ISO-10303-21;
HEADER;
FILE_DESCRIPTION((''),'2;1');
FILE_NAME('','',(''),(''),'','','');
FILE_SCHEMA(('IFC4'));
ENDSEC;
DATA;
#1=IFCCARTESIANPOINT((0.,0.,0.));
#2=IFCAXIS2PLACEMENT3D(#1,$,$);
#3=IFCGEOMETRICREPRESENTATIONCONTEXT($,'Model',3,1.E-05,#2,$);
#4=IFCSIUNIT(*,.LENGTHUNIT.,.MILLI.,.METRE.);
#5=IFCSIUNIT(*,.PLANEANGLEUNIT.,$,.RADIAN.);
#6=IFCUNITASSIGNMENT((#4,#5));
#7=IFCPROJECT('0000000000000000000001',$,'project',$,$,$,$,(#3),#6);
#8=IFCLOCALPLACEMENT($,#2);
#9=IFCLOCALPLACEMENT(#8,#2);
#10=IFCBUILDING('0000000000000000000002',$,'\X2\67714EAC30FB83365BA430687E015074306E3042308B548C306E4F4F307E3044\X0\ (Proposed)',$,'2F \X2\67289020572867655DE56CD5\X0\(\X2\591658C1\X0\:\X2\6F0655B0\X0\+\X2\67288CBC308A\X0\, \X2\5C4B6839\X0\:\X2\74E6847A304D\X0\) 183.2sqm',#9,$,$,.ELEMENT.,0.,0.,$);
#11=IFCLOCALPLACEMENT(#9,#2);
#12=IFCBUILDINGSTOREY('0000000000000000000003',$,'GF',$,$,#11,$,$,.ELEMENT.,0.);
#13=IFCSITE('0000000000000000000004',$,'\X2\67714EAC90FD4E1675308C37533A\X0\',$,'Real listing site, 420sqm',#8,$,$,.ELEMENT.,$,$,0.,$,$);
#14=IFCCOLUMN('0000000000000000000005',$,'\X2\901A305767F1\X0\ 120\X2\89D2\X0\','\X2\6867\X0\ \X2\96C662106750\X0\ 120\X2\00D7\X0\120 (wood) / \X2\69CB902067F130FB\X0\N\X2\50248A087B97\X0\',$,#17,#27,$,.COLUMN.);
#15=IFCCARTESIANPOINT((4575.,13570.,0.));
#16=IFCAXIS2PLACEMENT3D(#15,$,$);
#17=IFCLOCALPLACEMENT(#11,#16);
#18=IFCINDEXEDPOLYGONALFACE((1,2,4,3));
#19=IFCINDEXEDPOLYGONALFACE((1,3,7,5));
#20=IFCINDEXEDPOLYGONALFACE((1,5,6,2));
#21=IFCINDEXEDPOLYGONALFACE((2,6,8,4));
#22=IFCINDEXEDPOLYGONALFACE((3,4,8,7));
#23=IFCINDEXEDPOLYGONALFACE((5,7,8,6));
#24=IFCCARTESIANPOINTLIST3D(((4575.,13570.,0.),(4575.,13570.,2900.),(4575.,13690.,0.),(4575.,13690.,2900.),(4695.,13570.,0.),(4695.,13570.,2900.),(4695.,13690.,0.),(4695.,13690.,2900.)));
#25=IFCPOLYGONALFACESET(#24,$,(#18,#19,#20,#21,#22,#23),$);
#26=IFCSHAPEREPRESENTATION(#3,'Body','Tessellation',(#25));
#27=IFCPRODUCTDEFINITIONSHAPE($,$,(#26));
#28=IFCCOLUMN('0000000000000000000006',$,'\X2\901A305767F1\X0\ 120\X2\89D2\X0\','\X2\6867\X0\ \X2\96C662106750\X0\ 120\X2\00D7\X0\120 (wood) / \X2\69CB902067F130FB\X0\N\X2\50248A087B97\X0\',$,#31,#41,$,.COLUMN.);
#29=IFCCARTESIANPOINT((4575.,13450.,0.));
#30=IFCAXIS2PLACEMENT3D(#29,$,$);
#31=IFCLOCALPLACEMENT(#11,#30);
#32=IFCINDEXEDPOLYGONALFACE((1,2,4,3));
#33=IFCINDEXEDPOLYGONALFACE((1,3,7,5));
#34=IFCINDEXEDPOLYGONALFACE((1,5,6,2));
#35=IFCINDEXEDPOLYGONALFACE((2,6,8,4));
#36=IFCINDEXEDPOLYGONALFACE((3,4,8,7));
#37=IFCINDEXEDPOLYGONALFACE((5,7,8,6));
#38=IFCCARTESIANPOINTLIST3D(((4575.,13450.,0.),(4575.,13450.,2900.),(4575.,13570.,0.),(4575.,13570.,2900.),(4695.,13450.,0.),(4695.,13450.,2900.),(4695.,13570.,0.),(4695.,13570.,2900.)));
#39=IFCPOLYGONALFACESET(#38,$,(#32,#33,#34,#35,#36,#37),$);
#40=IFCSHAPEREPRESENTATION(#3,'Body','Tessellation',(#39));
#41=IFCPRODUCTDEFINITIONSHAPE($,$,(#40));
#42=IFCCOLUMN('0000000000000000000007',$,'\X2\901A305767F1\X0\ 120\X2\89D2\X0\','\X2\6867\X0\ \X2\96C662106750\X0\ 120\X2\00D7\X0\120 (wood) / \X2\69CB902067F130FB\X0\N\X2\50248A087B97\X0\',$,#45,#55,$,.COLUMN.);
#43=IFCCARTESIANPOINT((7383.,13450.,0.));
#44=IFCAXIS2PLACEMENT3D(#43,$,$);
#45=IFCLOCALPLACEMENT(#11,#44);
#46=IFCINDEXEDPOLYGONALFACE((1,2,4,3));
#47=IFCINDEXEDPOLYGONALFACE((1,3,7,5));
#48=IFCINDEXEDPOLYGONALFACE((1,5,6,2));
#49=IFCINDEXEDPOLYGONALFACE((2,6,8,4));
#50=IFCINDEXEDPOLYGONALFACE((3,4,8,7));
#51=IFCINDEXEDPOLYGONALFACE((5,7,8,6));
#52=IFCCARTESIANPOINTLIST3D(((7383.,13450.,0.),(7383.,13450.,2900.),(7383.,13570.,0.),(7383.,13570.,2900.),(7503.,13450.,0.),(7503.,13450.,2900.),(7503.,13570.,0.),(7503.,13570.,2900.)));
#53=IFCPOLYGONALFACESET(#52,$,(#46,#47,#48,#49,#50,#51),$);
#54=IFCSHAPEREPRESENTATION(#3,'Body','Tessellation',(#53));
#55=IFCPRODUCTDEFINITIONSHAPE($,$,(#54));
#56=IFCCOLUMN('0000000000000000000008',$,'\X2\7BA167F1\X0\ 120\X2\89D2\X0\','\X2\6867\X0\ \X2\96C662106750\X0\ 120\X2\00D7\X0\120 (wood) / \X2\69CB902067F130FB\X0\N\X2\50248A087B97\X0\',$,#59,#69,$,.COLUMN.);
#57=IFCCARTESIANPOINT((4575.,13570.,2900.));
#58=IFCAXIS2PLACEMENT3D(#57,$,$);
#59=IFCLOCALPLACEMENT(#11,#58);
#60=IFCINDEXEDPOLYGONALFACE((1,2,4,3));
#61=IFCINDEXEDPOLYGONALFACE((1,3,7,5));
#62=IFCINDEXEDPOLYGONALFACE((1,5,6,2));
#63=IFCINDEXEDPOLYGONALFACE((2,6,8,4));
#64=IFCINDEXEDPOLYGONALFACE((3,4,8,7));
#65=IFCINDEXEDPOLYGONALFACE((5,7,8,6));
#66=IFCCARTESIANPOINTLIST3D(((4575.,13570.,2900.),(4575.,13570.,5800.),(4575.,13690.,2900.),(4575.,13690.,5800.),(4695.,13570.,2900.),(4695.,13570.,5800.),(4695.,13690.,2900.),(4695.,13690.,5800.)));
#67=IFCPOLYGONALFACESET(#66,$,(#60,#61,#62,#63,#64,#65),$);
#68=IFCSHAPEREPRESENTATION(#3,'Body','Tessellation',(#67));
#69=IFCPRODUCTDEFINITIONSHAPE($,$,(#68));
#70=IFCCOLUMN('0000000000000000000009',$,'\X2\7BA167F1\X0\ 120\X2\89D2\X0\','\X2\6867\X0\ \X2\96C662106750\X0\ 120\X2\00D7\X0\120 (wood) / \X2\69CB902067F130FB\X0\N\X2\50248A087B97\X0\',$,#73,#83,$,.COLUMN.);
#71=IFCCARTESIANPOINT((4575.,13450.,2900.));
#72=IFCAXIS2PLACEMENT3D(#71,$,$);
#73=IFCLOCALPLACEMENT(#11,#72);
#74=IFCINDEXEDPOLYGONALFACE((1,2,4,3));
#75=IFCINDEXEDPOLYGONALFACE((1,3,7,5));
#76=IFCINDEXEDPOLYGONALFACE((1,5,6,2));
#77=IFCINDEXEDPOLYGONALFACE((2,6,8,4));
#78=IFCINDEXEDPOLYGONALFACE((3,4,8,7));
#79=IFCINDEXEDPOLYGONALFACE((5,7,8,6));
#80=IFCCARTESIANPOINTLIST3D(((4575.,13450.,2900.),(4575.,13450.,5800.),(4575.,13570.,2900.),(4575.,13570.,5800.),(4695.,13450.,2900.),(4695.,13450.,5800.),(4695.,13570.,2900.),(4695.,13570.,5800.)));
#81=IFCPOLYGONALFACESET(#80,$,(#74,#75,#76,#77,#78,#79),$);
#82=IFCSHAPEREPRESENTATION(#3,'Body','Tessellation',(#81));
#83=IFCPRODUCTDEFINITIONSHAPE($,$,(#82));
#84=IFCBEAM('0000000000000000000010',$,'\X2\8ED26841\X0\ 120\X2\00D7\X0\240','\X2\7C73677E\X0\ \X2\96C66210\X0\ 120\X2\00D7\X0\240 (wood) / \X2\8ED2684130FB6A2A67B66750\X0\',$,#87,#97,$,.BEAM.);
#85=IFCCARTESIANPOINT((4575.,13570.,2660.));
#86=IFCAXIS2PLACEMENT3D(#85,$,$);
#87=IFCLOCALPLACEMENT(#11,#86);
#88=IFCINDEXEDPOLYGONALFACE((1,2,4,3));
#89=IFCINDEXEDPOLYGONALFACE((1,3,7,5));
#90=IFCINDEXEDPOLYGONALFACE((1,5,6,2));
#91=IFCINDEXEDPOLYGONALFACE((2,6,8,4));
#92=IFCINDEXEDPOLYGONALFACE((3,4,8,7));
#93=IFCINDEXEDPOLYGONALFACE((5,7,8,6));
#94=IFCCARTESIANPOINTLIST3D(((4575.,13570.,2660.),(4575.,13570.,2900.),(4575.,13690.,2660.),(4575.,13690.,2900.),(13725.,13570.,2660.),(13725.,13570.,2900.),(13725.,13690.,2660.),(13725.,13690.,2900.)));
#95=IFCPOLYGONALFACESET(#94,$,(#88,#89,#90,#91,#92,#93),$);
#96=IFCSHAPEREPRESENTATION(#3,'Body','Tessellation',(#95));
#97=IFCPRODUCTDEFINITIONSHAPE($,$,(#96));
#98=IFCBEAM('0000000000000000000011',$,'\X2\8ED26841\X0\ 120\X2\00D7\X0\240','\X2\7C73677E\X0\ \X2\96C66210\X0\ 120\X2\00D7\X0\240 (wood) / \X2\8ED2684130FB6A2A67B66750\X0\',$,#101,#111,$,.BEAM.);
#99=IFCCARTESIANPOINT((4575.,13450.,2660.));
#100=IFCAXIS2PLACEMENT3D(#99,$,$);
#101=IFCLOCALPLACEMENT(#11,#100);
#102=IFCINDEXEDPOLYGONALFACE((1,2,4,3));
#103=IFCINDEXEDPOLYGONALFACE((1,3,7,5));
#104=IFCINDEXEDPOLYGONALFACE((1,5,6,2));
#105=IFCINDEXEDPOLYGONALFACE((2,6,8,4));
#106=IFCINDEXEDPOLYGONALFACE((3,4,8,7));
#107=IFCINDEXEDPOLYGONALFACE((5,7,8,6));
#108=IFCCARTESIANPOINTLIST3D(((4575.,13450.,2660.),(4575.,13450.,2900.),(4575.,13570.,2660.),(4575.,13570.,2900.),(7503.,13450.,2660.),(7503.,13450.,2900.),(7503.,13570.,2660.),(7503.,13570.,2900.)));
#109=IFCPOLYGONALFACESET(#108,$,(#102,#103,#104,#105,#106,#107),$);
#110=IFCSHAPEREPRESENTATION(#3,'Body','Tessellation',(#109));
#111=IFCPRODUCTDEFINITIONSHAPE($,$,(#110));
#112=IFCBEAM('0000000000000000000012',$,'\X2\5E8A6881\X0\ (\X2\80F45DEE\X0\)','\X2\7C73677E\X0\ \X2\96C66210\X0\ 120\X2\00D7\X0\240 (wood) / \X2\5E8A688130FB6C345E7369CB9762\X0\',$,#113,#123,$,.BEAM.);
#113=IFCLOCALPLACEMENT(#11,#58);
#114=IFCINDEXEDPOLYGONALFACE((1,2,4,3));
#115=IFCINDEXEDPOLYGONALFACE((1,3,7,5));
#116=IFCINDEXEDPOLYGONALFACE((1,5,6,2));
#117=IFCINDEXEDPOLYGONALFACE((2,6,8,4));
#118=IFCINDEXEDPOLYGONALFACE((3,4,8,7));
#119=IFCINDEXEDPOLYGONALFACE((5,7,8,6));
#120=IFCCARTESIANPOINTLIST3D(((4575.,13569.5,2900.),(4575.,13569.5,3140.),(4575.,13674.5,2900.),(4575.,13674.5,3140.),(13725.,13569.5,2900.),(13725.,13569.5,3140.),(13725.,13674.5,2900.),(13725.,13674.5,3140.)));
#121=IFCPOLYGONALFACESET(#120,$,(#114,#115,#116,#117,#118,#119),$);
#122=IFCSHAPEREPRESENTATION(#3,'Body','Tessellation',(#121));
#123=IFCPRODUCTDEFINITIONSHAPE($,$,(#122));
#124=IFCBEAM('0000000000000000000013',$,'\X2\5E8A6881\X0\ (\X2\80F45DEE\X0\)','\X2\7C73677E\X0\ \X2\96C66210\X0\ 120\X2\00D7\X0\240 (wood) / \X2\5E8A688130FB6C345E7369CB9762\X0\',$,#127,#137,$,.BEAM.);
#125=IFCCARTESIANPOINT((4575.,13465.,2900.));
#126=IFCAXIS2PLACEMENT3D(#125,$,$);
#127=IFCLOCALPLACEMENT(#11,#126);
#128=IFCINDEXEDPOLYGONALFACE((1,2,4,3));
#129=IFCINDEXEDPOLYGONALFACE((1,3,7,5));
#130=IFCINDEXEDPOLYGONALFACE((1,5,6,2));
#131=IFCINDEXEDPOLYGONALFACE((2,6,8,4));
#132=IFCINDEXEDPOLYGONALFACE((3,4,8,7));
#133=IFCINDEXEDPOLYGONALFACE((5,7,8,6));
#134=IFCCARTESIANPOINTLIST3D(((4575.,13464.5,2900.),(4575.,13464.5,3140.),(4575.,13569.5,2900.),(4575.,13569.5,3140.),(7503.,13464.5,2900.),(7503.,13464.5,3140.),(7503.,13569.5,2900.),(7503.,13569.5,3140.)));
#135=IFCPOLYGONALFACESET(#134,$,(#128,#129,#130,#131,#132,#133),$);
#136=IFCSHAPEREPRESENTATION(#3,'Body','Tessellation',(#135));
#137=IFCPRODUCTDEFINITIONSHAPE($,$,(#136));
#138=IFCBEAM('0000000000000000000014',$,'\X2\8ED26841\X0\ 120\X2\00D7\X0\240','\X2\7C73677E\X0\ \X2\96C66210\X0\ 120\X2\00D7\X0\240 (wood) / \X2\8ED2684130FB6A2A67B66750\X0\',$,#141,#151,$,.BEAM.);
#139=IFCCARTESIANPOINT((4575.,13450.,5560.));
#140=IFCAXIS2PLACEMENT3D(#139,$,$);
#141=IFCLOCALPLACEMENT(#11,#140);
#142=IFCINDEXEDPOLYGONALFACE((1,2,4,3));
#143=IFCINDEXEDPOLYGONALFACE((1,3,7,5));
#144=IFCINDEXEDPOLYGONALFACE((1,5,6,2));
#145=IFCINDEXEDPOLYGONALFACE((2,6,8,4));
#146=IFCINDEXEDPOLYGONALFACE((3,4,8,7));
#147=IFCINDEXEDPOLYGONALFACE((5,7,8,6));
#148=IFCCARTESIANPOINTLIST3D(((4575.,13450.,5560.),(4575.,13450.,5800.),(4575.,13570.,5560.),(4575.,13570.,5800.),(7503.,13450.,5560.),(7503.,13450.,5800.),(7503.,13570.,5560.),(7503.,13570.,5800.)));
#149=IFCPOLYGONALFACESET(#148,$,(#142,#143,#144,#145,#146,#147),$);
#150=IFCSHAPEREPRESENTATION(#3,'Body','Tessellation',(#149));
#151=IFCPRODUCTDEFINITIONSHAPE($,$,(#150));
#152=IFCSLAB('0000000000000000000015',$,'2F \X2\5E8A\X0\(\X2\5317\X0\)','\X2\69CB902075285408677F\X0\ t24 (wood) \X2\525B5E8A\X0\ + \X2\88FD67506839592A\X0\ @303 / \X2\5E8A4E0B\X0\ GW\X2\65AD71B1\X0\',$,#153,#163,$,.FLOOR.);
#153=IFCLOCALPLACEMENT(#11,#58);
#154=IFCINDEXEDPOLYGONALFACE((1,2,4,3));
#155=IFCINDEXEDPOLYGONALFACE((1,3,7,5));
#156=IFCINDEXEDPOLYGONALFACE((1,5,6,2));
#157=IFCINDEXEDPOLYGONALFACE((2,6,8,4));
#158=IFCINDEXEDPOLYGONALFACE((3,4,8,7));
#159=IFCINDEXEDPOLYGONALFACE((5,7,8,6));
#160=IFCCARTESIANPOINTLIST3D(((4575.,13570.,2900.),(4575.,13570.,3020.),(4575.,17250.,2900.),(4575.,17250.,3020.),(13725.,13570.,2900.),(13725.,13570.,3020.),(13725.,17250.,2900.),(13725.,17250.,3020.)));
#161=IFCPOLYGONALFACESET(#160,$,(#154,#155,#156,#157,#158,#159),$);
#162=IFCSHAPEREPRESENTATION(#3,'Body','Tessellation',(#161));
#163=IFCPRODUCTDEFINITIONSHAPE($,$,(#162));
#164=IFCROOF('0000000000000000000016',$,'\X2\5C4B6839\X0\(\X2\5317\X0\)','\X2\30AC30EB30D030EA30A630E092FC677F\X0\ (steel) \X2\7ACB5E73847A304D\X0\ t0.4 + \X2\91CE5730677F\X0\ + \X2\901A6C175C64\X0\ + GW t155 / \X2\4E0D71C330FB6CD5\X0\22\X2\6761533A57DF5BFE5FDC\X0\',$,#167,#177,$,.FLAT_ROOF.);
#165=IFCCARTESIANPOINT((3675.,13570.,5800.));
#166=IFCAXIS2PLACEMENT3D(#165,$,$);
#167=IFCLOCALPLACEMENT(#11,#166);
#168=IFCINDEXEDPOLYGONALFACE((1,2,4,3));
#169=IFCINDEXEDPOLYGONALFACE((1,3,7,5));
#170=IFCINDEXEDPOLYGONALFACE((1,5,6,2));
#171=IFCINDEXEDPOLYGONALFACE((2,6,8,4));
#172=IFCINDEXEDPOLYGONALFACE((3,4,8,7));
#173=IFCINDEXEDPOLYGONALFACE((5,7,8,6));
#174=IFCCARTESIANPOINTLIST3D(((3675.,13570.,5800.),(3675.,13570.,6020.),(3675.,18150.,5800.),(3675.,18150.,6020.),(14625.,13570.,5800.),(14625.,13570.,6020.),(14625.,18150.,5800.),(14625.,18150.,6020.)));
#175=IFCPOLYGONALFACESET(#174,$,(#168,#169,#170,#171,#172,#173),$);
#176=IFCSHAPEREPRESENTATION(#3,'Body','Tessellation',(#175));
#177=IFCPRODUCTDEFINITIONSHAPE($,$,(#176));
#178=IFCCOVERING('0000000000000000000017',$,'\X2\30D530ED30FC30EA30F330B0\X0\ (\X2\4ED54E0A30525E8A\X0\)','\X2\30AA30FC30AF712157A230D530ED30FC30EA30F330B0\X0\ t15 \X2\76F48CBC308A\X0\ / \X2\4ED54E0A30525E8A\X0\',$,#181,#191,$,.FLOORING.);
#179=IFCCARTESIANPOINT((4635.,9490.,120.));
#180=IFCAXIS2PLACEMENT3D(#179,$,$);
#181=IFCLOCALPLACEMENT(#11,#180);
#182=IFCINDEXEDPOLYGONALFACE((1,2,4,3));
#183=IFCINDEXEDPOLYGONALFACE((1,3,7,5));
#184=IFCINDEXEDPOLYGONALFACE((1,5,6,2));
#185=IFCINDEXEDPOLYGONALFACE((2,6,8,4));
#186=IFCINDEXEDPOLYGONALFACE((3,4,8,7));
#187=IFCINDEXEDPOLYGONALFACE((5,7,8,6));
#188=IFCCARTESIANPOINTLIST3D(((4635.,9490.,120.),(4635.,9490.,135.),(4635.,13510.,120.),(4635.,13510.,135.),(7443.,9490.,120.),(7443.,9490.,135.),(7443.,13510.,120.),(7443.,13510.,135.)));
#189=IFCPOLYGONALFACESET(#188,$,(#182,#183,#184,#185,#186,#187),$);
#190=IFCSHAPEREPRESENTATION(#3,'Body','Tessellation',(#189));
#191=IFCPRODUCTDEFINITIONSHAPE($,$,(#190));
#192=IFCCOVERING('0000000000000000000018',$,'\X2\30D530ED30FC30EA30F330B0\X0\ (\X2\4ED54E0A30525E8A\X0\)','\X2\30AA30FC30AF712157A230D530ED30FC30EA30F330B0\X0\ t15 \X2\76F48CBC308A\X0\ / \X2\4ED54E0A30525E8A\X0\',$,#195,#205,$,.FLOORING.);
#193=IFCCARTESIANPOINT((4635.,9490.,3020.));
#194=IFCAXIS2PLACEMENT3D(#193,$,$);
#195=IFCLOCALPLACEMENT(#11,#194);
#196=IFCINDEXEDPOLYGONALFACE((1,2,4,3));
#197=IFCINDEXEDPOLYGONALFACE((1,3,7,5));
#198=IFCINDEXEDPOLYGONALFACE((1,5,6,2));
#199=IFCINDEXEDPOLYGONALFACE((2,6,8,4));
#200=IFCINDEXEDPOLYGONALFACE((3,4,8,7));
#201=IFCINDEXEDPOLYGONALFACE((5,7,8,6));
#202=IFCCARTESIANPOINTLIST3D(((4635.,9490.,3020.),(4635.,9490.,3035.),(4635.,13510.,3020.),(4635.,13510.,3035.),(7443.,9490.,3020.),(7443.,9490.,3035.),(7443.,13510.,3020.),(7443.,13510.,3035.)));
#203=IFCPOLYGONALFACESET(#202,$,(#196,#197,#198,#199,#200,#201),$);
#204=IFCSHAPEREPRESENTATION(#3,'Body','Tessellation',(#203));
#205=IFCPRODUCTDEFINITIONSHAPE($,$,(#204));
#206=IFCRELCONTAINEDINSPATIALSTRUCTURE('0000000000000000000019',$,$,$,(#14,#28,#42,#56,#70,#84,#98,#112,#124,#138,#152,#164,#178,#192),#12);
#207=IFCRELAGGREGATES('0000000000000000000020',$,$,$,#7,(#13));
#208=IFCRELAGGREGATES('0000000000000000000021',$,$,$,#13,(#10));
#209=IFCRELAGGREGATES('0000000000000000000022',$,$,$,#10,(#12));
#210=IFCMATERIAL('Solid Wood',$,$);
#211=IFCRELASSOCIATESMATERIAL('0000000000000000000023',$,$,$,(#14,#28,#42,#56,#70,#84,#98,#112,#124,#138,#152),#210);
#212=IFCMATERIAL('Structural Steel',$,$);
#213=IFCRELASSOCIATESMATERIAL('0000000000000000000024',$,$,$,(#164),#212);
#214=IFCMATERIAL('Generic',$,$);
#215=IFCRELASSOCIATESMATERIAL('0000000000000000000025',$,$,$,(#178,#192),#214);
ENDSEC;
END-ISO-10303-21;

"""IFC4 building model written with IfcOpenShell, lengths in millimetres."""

from ifc_helpers import new_model, si_unit, frame, frame_2d, origin, place, context, project, spatial, rectangle, extrude, material, element, save


model = new_model("IFC4")

# Units and contexts
model_context = context("Model", 3, precision=1e-05, world=origin())
ifc_project = project(units=[si_unit("LENGTHUNIT", "METRE", prefix="MILLI"), si_unit("PLANEANGLEUNIT", "RADIAN")], contexts=[model_context])

# Site, building, storey
site_placement = place(None, origin())
site = spatial("IfcSite", under=ifc_project, at=site_placement, Name="東京都世田谷区", ObjectType="Real listing site, 420sqm", CompositionType="ELEMENT", RefElevation=0.0)
building_placement = place(site_placement, origin())
building = spatial("IfcBuilding", under=site, at=building_placement, Name="東京・茶室と縁側のある和の住まい (Proposed)", ObjectType="2F 木造在来工法(外壁:漆喰+木貼り, 屋根:瓦葺き) 183.2sqm", CompositionType="ELEMENT", ElevationOfRefHeight=0.0, ElevationOfTerrain=0.0)
storey_placement = place(building_placement, origin())
storey = spatial("IfcBuildingStorey", under=building, at=storey_placement, Name="GF", CompositionType="ELEMENT", Elevation=0.0)

# Columns
ifc_material_1 = material(Name="Solid Wood")
column_1_placement = place(storey_placement, frame((4575.0, 13570.0, 0.0)))
element("IfcColumn", 1, at=column_1_placement, inside=storey, material=ifc_material_1, Name="通し柱 120角", Description="桧 集成材 120×120 (wood) / 構造柱・N値計算", PredefinedType="COLUMN", context=model_context, shape_type="SweptSolid", body=[
    extrude(rectangle(XDim=120.0, YDim=120.0, at=frame_2d((60.0, 60.0))), frame((4575.0, 13570.0, 0.0)), (0.0, 0.0, 1.0), 2900.0),
])
column_2_placement = place(storey_placement, frame((4575.0, 13450.0, 0.0)))
element("IfcColumn", 2, at=column_2_placement, inside=storey, material=ifc_material_1, Name="通し柱 120角", Description="桧 集成材 120×120 (wood) / 構造柱・N値計算", PredefinedType="COLUMN", context=model_context, shape_type="SweptSolid", body=[
    extrude(rectangle(XDim=120.0, YDim=120.0, at=frame_2d((60.0, 60.0))), frame((4575.0, 13450.0, 0.0)), (0.0, 0.0, 1.0), 2900.0),
])
column_3_placement = place(storey_placement, frame((7383.0, 13450.0, 0.0)))
element("IfcColumn", 3, at=column_3_placement, inside=storey, material=ifc_material_1, Name="通し柱 120角", Description="桧 集成材 120×120 (wood) / 構造柱・N値計算", PredefinedType="COLUMN", context=model_context, shape_type="SweptSolid", body=[
    extrude(rectangle(XDim=120.0, YDim=120.0, at=frame_2d((60.0, 60.0))), frame((7383.0, 13450.0, 0.0)), (0.0, 0.0, 1.0), 2900.0),
])
column_4_placement = place(storey_placement, frame((4575.0, 13570.0, 2900.0)))
element("IfcColumn", 4, at=column_4_placement, inside=storey, material=ifc_material_1, Name="管柱 120角", Description="桧 集成材 120×120 (wood) / 構造柱・N値計算", PredefinedType="COLUMN", context=model_context, shape_type="SweptSolid", body=[
    extrude(rectangle(XDim=120.0, YDim=120.0, at=frame_2d((60.0, 60.0))), frame((4575.0, 13570.0, 2900.0)), (0.0, 0.0, 1.0), 2900.0),
])
column_5_placement = place(storey_placement, frame((4575.0, 13450.0, 2900.0)))
element("IfcColumn", 5, at=column_5_placement, inside=storey, material=ifc_material_1, Name="管柱 120角", Description="桧 集成材 120×120 (wood) / 構造柱・N値計算", PredefinedType="COLUMN", context=model_context, shape_type="SweptSolid", body=[
    extrude(rectangle(XDim=120.0, YDim=120.0, at=frame_2d((60.0, 60.0))), frame((4575.0, 13450.0, 2900.0)), (0.0, 0.0, 1.0), 2900.0),
])

# Beams
beam_1_placement = place(storey_placement, frame((4575.0, 13570.0, 2660.0)))
element("IfcBeam", 6, at=beam_1_placement, inside=storey, material=ifc_material_1, Name="軒桁 120×240", Description="米松 集成 120×240 (wood) / 軒桁・横架材", PredefinedType="BEAM", context=model_context, shape_type="SweptSolid", body=[
    extrude(rectangle(XDim=9150.0, YDim=120.0, at=frame_2d((4575.0, 60.0))), frame((4575.0, 13570.0, 2660.0)), (0.0, 0.0, 1.0), 240.0),
])
beam_2_placement = place(storey_placement, frame((4575.0, 13450.0, 2660.0)))
element("IfcBeam", 7, at=beam_2_placement, inside=storey, material=ifc_material_1, Name="軒桁 120×240", Description="米松 集成 120×240 (wood) / 軒桁・横架材", PredefinedType="BEAM", context=model_context, shape_type="SweptSolid", body=[
    extrude(rectangle(XDim=2928.0, YDim=120.0, at=frame_2d((1464.0, 60.0))), frame((4575.0, 13450.0, 2660.0)), (0.0, 0.0, 1.0), 240.0),
])
beam_3_placement = place(storey_placement, frame((4575.0, 13570.0, 2900.0)))
element("IfcBeam", 8, at=beam_3_placement, inside=storey, material=ifc_material_1, Name="床梁 (胴差)", Description="米松 集成 120×240 (wood) / 床梁・水平構面", PredefinedType="BEAM", context=model_context, shape_type="SweptSolid", body=[
    extrude(rectangle(XDim=9150.0, YDim=105.0, at=frame_2d((4575.0, 52.0))), frame((4575.0, 13570.0, 2900.0)), (0.0, 0.0, 1.0), 240.0),
])
beam_4_placement = place(storey_placement, frame((4575.0, 13465.0, 2900.0)))
element("IfcBeam", 9, at=beam_4_placement, inside=storey, material=ifc_material_1, Name="床梁 (胴差)", Description="米松 集成 120×240 (wood) / 床梁・水平構面", PredefinedType="BEAM", context=model_context, shape_type="SweptSolid", body=[
    extrude(rectangle(XDim=2928.0, YDim=105.0, at=frame_2d((1464.0, 52.0))), frame((4575.0, 13465.0, 2900.0)), (0.0, 0.0, 1.0), 240.0),
])
beam_5_placement = place(storey_placement, frame((4575.0, 13450.0, 5560.0)))
element("IfcBeam", 10, at=beam_5_placement, inside=storey, material=ifc_material_1, Name="軒桁 120×240", Description="米松 集成 120×240 (wood) / 軒桁・横架材", PredefinedType="BEAM", context=model_context, shape_type="SweptSolid", body=[
    extrude(rectangle(XDim=2928.0, YDim=120.0, at=frame_2d((1464.0, 60.0))), frame((4575.0, 13450.0, 5560.0)), (0.0, 0.0, 1.0), 240.0),
])

# Slab
slab_1_placement = place(storey_placement, frame((4575.0, 13570.0, 2900.0)))
element("IfcSlab", 11, at=slab_1_placement, inside=storey, material=ifc_material_1, Name="2F 床(北)", Description="構造用合板 t24 (wood) 剛床 + 製材根太 @303 / 床下 GW断熱", PredefinedType="FLOOR", context=model_context, shape_type="SweptSolid", body=[
    extrude(rectangle(XDim=9150.0, YDim=3680.0, at=frame_2d((4575.0, 1840.0))), frame((4575.0, 13570.0, 2900.0)), (0.0, 0.0, 1.0), 120.0),
])

# Roof
ifc_material_2 = material(Name="Structural Steel")
for number, where, name in (
    (12, (3675.0, 13570.0, 5800.0), "屋根(北)"),
):
    element("IfcRoof", number, at=place(storey_placement, frame(where)), inside=storey, material=ifc_material_2, Name=name, Description="ガルバリウム鋼板 (steel) 立平葺き t0.4 + 野地板 + 通気層 + GW t155 / 不燃・法22条区域対応", PredefinedType="FLAT_ROOF", context=model_context, shape_type="SweptSolid", body=[
        extrude(rectangle(XDim=10950.0, YDim=4580.0, at=frame_2d((5475.0, 2290.0))), frame((3675.0, 13570.0, 5800.0)), (0.0, 0.0, 1.0), 220.0),
    ])

# Coverings
ifc_material_3 = material(Name="Generic")
covering_1_placement = place(storey_placement, frame((4635.0, 9490.0, 120.0)))
element("IfcCovering", 13, at=covering_1_placement, inside=storey, material=ifc_material_3, Name="フローリング (仕上げ床)", Description="オーク無垢フローリング t15 直貼り / 仕上げ床", PredefinedType="FLOORING", context=model_context, shape_type="SweptSolid", body=[
    extrude(rectangle(XDim=2808.0, YDim=4020.0, at=frame_2d((1404.0, 2010.0))), frame((4635.0, 9490.0, 120.0)), (0.0, 0.0, 1.0), 15.0),
])
covering_2_placement = place(storey_placement, frame((4635.0, 9490.0, 3020.0)))
element("IfcCovering", 14, at=covering_2_placement, inside=storey, material=ifc_material_3, Name="フローリング (仕上げ床)", Description="オーク無垢フローリング t15 直貼り / 仕上げ床", PredefinedType="FLOORING", context=model_context, shape_type="SweptSolid", body=[
    extrude(rectangle(XDim=2808.0, YDim=4020.0, at=frame_2d((1404.0, 2010.0))), frame((4635.0, 9490.0, 3020.0)), (0.0, 0.0, 1.0), 15.0),
])

save(model, "model.ifc")
